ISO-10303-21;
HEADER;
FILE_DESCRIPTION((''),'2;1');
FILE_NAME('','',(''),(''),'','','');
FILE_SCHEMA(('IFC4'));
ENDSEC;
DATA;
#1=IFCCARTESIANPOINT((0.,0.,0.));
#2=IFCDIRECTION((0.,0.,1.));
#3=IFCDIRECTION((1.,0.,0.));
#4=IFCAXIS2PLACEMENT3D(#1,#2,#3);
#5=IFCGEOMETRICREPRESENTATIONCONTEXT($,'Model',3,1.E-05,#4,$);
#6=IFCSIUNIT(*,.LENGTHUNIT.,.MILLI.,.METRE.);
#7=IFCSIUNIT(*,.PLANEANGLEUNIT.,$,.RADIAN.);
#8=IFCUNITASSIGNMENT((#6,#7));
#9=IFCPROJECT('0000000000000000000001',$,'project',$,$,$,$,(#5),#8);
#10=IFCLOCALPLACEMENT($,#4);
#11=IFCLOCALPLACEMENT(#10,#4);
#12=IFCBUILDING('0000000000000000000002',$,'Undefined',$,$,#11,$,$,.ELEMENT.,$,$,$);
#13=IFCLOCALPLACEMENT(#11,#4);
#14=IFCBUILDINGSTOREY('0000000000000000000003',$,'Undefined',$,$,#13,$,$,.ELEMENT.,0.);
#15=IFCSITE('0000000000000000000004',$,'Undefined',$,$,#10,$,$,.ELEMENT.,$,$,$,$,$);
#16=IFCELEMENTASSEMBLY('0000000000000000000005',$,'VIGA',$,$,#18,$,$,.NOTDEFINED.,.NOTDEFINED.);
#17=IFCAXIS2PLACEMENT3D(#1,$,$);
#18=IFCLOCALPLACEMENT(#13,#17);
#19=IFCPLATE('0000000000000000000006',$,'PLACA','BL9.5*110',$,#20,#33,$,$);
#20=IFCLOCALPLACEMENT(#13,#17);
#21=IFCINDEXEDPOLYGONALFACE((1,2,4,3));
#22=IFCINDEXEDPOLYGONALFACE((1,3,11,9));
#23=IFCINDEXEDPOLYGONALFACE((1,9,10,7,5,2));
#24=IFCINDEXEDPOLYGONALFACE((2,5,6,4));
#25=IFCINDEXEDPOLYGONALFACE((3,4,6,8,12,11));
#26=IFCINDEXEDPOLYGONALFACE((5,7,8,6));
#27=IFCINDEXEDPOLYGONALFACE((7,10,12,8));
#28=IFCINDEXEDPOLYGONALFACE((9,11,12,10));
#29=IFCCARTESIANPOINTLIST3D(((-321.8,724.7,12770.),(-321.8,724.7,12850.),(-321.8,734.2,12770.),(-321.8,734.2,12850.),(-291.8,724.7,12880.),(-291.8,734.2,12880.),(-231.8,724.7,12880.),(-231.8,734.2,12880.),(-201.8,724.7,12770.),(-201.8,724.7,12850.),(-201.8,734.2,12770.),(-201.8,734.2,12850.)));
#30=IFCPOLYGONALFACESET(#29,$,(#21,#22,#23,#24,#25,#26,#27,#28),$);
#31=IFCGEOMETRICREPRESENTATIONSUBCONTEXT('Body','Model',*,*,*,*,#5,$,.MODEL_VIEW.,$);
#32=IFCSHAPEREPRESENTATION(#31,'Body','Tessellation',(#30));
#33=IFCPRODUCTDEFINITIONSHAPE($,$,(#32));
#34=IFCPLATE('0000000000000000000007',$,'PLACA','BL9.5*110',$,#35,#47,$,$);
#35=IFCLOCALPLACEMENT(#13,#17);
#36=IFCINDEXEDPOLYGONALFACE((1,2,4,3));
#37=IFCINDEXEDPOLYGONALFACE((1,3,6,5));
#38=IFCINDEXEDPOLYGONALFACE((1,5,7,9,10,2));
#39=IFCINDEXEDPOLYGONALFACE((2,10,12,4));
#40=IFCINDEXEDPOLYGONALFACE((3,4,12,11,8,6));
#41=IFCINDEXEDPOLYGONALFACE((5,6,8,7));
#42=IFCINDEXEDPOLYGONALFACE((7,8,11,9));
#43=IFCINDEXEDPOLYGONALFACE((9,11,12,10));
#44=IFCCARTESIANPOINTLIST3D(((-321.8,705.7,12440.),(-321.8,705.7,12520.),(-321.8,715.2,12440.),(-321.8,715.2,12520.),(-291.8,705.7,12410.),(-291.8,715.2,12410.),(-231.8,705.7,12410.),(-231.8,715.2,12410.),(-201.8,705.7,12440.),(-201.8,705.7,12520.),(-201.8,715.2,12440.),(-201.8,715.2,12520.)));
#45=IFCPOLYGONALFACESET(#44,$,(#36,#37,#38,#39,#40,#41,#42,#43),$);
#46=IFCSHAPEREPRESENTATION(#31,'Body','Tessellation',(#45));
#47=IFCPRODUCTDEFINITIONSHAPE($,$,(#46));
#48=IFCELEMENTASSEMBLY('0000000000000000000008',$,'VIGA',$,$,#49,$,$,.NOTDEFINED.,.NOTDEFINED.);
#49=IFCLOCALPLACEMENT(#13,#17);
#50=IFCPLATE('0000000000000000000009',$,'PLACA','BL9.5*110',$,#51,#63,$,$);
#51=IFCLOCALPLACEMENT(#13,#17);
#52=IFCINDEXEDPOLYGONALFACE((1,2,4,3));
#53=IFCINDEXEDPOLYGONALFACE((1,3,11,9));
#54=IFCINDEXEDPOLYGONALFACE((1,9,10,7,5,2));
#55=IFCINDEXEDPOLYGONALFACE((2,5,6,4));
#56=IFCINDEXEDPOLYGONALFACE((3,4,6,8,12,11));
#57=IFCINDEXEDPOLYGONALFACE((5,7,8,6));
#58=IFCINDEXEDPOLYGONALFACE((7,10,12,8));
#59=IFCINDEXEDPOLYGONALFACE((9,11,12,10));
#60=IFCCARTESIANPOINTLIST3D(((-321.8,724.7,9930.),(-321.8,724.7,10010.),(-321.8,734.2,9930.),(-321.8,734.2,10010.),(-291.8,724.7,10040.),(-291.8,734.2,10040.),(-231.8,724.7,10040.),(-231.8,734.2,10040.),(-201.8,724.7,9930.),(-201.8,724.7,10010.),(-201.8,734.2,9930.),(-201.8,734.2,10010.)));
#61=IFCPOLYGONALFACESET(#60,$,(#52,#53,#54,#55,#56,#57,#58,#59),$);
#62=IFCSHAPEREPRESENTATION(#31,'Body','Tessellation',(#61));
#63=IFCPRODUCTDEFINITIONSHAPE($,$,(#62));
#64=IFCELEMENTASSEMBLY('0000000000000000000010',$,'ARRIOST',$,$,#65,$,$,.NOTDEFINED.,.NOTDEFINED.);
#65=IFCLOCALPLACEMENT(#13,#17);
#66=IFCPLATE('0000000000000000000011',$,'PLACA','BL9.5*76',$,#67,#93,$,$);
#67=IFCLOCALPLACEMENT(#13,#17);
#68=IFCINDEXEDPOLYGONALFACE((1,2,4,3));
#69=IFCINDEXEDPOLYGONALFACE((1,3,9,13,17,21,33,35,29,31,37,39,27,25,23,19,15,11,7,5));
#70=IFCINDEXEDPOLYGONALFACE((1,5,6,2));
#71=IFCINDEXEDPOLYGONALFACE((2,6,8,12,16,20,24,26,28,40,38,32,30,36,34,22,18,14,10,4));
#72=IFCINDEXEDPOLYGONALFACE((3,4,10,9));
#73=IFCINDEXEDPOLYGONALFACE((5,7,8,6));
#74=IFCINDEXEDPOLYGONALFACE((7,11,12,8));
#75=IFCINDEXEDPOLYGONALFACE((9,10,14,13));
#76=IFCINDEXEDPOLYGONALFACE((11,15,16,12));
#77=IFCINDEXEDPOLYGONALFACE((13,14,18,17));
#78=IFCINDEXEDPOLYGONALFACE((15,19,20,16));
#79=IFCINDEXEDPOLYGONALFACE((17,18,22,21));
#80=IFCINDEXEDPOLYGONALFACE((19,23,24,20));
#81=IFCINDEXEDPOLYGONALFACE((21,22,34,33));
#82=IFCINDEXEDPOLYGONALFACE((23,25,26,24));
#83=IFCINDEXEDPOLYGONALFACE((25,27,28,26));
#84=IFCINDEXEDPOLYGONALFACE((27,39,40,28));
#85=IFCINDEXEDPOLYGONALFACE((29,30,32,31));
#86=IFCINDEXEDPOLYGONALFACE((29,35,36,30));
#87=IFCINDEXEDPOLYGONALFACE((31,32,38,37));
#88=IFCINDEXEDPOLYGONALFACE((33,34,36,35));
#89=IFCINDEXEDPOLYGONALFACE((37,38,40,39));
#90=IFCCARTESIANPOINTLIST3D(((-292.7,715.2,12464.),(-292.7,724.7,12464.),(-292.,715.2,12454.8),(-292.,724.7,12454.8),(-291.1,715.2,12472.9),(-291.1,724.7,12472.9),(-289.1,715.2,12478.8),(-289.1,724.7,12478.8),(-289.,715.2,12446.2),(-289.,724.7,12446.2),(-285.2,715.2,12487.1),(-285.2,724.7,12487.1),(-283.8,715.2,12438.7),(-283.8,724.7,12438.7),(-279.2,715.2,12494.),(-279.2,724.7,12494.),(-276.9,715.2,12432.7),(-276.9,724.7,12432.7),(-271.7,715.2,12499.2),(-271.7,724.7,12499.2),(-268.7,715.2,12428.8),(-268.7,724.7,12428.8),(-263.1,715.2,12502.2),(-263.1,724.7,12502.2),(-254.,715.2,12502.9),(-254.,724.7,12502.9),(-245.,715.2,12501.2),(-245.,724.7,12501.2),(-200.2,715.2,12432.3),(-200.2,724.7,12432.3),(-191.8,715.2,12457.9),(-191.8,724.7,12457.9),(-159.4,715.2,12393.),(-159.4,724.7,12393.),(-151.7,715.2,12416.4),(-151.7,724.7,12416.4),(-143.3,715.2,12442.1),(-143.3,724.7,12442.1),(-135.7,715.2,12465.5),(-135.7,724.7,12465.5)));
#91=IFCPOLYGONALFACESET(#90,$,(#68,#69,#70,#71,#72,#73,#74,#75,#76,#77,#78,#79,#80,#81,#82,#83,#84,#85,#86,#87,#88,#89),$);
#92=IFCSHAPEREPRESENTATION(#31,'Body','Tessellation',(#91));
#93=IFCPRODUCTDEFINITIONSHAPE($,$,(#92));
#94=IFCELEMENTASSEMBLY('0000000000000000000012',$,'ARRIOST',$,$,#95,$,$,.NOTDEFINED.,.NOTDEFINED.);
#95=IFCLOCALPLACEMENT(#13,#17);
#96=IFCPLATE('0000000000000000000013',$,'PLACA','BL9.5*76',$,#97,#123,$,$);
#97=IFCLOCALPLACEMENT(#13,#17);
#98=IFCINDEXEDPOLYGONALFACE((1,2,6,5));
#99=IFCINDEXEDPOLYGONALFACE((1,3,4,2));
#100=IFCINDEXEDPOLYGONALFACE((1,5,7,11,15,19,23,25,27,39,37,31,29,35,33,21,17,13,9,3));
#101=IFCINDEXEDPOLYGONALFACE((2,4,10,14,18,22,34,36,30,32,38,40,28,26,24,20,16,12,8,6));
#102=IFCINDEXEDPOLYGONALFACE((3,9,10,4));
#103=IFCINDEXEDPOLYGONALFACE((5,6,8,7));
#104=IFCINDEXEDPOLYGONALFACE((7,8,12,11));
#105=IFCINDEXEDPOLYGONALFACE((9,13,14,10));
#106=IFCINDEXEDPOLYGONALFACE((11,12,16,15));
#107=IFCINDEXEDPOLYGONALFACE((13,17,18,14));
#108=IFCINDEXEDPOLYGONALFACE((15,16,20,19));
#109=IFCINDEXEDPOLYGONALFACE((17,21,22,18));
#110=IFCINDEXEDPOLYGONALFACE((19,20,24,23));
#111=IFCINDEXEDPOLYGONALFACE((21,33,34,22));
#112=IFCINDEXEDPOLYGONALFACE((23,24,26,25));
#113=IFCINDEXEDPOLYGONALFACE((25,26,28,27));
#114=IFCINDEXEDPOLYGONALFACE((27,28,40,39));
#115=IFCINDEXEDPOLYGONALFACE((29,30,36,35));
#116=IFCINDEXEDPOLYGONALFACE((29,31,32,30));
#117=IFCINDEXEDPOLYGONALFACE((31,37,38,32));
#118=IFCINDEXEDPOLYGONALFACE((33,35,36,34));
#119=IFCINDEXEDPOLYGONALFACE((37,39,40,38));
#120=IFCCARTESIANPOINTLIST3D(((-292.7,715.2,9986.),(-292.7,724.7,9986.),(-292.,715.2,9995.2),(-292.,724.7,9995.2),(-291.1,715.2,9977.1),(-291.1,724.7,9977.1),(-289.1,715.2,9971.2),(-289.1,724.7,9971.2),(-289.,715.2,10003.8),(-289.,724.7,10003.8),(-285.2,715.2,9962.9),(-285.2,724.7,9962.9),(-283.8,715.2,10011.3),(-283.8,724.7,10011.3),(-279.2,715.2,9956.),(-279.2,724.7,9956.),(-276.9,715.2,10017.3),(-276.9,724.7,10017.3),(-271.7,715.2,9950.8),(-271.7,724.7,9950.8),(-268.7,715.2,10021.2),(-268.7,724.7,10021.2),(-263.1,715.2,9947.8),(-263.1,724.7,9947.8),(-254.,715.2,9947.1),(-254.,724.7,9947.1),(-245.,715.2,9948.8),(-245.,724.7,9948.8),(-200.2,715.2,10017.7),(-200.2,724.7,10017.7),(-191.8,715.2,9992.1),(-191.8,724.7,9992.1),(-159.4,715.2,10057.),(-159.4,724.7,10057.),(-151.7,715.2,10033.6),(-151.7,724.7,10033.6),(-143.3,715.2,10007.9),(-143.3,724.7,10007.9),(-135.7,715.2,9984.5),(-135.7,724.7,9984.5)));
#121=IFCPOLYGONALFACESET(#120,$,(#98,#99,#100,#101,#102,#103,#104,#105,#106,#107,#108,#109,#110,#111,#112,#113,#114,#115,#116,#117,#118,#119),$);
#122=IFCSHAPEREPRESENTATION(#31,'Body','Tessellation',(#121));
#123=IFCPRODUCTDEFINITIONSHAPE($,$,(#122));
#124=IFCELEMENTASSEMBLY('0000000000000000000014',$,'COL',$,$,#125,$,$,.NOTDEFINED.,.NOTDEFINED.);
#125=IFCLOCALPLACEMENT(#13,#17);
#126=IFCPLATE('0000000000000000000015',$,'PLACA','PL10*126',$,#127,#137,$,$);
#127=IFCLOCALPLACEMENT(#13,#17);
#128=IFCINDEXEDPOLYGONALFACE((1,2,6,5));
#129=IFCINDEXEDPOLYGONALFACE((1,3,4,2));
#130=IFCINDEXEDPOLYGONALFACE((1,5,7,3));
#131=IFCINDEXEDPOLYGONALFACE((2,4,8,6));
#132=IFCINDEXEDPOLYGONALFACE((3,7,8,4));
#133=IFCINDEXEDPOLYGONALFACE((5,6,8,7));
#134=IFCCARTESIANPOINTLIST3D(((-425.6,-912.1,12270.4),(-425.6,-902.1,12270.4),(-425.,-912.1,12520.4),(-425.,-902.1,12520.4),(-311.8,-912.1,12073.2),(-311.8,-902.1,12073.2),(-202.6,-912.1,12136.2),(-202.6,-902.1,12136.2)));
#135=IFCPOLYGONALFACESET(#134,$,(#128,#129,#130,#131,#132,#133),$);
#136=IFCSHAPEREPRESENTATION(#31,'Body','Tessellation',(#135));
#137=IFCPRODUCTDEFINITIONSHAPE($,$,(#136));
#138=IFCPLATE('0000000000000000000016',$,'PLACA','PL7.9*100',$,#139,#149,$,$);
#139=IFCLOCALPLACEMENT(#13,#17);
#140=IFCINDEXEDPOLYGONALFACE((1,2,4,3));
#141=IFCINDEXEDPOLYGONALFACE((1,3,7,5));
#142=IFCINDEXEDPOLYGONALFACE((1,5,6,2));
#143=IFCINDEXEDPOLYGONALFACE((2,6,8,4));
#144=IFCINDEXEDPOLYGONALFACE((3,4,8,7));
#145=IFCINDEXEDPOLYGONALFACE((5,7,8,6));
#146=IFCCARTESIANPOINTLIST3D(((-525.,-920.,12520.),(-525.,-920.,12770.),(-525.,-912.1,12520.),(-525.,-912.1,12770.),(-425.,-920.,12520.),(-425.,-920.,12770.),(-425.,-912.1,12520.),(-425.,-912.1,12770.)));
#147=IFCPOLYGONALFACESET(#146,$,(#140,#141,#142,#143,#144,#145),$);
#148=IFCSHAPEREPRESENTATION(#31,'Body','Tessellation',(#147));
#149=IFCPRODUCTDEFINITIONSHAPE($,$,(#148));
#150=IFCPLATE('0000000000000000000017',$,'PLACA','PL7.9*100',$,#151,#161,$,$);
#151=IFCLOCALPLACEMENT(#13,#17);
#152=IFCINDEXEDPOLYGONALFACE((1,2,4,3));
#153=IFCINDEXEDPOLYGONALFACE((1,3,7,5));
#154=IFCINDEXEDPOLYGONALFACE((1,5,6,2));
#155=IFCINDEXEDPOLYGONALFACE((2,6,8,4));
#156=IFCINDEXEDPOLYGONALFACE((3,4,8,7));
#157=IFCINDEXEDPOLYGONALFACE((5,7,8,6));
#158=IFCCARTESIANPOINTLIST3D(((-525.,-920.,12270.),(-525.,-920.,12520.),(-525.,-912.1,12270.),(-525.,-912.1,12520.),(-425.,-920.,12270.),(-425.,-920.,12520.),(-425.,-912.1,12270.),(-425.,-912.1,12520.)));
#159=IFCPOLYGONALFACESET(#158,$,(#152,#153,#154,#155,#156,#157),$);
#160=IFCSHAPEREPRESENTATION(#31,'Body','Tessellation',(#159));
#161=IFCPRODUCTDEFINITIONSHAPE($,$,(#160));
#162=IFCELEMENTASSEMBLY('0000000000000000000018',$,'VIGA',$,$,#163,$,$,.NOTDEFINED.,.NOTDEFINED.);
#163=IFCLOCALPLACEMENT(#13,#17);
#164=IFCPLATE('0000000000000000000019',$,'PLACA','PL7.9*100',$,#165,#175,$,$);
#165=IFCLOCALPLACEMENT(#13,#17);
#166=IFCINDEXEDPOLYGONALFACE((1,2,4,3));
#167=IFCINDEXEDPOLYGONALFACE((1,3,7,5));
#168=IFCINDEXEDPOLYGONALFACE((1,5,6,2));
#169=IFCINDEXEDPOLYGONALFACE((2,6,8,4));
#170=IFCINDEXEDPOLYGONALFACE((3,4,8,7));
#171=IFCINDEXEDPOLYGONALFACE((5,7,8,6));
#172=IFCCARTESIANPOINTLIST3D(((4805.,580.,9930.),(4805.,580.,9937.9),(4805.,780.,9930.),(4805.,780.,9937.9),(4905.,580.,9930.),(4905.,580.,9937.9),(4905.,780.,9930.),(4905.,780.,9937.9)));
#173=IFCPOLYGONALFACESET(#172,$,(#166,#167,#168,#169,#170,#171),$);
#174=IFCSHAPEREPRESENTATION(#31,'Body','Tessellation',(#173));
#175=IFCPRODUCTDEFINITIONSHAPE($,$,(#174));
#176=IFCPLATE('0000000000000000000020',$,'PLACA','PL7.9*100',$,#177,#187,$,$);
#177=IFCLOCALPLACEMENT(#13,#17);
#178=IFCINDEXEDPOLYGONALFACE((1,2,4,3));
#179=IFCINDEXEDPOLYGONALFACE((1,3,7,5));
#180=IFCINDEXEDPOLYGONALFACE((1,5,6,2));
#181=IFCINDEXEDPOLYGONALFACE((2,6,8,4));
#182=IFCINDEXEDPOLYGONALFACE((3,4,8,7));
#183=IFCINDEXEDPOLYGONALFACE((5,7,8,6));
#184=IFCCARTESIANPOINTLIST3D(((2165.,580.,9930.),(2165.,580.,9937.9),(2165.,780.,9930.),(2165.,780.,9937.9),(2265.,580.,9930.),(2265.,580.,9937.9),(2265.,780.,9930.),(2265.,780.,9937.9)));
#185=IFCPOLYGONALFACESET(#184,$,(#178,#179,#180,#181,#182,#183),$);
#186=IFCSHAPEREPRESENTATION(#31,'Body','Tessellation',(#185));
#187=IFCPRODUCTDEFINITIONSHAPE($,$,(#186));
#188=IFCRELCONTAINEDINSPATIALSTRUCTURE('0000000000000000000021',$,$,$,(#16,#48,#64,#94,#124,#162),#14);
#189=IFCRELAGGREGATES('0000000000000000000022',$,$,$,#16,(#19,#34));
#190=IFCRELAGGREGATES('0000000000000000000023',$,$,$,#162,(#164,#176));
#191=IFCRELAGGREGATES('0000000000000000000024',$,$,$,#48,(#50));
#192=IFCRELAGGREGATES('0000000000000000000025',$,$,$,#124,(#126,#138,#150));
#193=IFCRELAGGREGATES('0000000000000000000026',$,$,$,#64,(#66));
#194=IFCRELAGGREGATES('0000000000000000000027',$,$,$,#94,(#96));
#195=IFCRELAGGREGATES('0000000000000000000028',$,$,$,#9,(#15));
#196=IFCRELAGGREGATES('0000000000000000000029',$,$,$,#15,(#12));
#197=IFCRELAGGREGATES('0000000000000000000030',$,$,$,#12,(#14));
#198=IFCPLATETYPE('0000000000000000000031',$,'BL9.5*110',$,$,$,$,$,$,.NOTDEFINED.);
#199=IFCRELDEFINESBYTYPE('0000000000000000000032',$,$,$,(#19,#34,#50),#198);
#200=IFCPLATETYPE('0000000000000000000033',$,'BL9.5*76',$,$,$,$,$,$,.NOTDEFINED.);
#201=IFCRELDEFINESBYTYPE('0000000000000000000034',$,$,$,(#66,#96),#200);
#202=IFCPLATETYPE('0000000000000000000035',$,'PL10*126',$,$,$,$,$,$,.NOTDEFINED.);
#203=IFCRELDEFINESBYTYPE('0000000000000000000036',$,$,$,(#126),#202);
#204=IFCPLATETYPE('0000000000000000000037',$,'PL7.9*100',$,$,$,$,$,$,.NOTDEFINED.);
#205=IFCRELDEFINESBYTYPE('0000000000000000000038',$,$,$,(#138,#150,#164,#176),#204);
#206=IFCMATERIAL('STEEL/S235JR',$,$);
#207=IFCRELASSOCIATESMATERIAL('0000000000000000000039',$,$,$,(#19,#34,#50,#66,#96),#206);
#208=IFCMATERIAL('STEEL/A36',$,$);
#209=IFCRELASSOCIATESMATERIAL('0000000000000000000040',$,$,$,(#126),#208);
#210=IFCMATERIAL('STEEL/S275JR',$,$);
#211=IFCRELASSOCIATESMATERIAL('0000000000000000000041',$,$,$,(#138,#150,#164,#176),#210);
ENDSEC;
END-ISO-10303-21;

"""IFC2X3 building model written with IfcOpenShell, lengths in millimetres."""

from ifc_helpers import new_model, si_unit, frame, frame_2d, origin_with_axes, origin_2d_with_axis, place, context, subcontext, project, spatial, polyline, circle_curve, parameter, trimmed, segment, composite_curve, rectangle, outline, extrude, boolean, material, type_object, element, aggregate, save


model = new_model("IFC2X3")

# Units and contexts
model_context = context("Model", 3, precision=1e-05, world=origin_with_axes())
body_context = subcontext(model_context, "Body", "Model", "MODEL_VIEW")
ifc_project = project(units=[si_unit("LENGTHUNIT", "METRE", prefix="MILLI"), si_unit("PLANEANGLEUNIT", "RADIAN")], contexts=[model_context])

# Site, building, storey
site_placement = place(None, origin_with_axes())
site = spatial("IfcSite", under=ifc_project, at=site_placement, Name="Undefined", CompositionType="ELEMENT")
building_placement = place(site_placement, origin_with_axes())
building = spatial("IfcBuilding", under=site, at=building_placement, Name="Undefined", CompositionType="ELEMENT")
storey_placement = place(building_placement, origin_with_axes())
storey = spatial("IfcBuildingStorey", under=building, at=storey_placement, Name="Undefined", CompositionType="ELEMENT", Elevation=0.0)

# Element assembly, plates
assembly_1_placement = place(storey_placement, origin_with_axes())
assembly_1 = element("IfcElementAssembly", 1, at=assembly_1_placement, inside=storey, Name="VIGA", AssemblyPlace="NOTDEFINED", PredefinedType="NOTDEFINED")
ifc_material_1 = material(Name="STEEL/S235JR")
plate_type_1 = type_object("IfcPlateType", Name="BL9.5*110", PredefinedType="NOTDEFINED")
plate_1_placement = place(assembly_1_placement, frame((-201.8, 729.5, 12770.0), z_axis=(0.0, -1.0, 0.0), x_axis=(0.0, 0.0, 1.0)))
plate_1 = element("IfcPlate", 2, at=plate_1_placement, type_object=plate_type_1, material=ifc_material_1, Name="PLACA", Description="BL9.5*110", context=body_context, shape_type="SweptSolid", body=[
    extrude(outline(polyline([(0.0, 0.0), (80.0, 0.0), (110.0, 30.0), (110.0, 90.0), (80.0, 120.0), (0.0, 120.0), (0.0, 0.0)])), frame((0.0, 0.0, -4.7), z_axis=(0.0, 0.0, 1.0), x_axis=(1.0, 0.0, 0.0)), (0.0, 0.0, 1.0), 9.5),
])
plate_2_placement = place(assembly_1_placement, frame((-201.8, 710.5, 12520.0), z_axis=(0.0, 1.0, 0.0), x_axis=(0.0, 0.0, -1.0)))
plate_2 = element("IfcPlate", 3, at=plate_2_placement, type_object=plate_type_1, material=ifc_material_1, Name="PLACA", Description="BL9.5*110", context=body_context, shape_type="SweptSolid", body=[
    extrude(outline(polyline([(0.0, 0.0), (80.0, 0.0), (110.0, 30.0), (110.0, 90.0), (80.0, 120.0), (0.0, 120.0), (0.0, 0.0)])), frame((0.0, 0.0, -4.7), z_axis=(0.0, 0.0, 1.0), x_axis=(1.0, 0.0, 0.0)), (0.0, 0.0, 1.0), 9.5),
])

# Element assemblies, plates
assembly_2_placement = place(storey_placement, origin_with_axes())
assembly_2 = element("IfcElementAssembly", 4, at=assembly_2_placement, inside=storey, Name="VIGA", AssemblyPlace="NOTDEFINED", PredefinedType="NOTDEFINED")
plate_3_placement = place(assembly_2_placement, frame((-201.8, 729.5, 9930.0), z_axis=(0.0, -1.0, 0.0), x_axis=(0.0, 0.0, 1.0)))
plate_3 = element("IfcPlate", 5, at=plate_3_placement, type_object=plate_type_1, material=ifc_material_1, Name="PLACA", Description="BL9.5*110", context=body_context, shape_type="SweptSolid", body=[
    extrude(outline(polyline([(0.0, 0.0), (80.0, 0.0), (110.0, 30.0), (110.0, 90.0), (80.0, 120.0), (0.0, 120.0), (0.0, 0.0)])), frame((0.0, 0.0, -4.7), z_axis=(0.0, 0.0, 1.0), x_axis=(1.0, 0.0, 0.0)), (0.0, 0.0, 1.0), 9.5),
])
assembly_3_placement = place(storey_placement, origin_with_axes())
assembly_3 = element("IfcElementAssembly", 6, at=assembly_3_placement, inside=storey, Name="ARRIOST", AssemblyPlace="NOTDEFINED", PredefinedType="NOTDEFINED")
plate_type_2 = type_object("IfcPlateType", Name="BL9.5*76", PredefinedType="NOTDEFINED")
plate_4_placement = place(assembly_3_placement, frame((-301.9, 720.0, 12439.7), z_axis=(0.0, 1.0, 0.0), x_axis=(0.310857, 0.0, 0.950457)))
plate_4 = element("IfcPlate", 7, at=plate_4_placement, type_object=plate_type_2, material=ifc_material_1, Name="PLACA", Description="BL9.5*76", context=body_context, shape_type="CSG", body=[
    boolean("DIFFERENCE", extrude(outline(composite_curve([segment(trimmed(circle_curve(frame_2d((35.0, 35.0), x_axis=(-1.0, 0.0)), 35.0), [parameter(0.0)], [parameter(1.570796)], True, "PARAMETER"), True, "CONTINUOUS"), segment(polyline([(35.0, 0.0), (41.2, 0.0)]), True, "CONTINUOUS"), segment(trimmed(circle_curve(frame_2d((41.2, 35.0), x_axis=(0.0, -1.0)), 35.0), [parameter(0.0)], [parameter(1.570796)], True, "PARAMETER"), True, "CONTINUOUS"), segment(polyline([(76.2, 35.0), (76.2, 150.0), (0.0, 150.0), (0.0, 35.0)]), True, "CONTINUOUS")], self_intersect=True)), frame((0.0, 0.0, -4.7), z_axis=(0.0, 0.0, 1.0), x_axis=(1.0, 0.0, 0.0)), (0.0, 0.0, 1.0), 9.5), extrude(rectangle(XDim=27.0, YDim=27.0, at=origin_2d_with_axis()), frame((38.1, 250.0, 0.0), z_axis=(0.0, -1.0, 0.0), x_axis=(-1.0, 0.0, 0.0)), (0.0, 0.0, 1.0), 151.0)),
])
assembly_4_placement = place(storey_placement, origin_with_axes())
assembly_4 = element("IfcElementAssembly", 8, at=assembly_4_placement, inside=storey, Name="ARRIOST", AssemblyPlace="NOTDEFINED", PredefinedType="NOTDEFINED")
plate_5_placement = place(assembly_4_placement, frame((-301.9, 720.0, 10010.3), z_axis=(0.0, -1.0, 0.0), x_axis=(0.310822, 0.0, -0.950468)))
plate_5 = element("IfcPlate", 9, at=plate_5_placement, type_object=plate_type_2, material=ifc_material_1, Name="PLACA", Description="BL9.5*76", context=body_context, shape_type="CSG", body=[
    boolean("DIFFERENCE", extrude(outline(composite_curve([segment(trimmed(circle_curve(frame_2d((35.0, 35.0), x_axis=(-1.0, 0.0)), 35.0), [parameter(0.0)], [parameter(1.570796)], True, "PARAMETER"), True, "CONTINUOUS"), segment(polyline([(35.0, 0.0), (41.2, 0.0)]), True, "CONTINUOUS"), segment(trimmed(circle_curve(frame_2d((41.2, 35.0), x_axis=(0.0, -1.0)), 35.0), [parameter(0.0)], [parameter(1.570796)], True, "PARAMETER"), True, "CONTINUOUS"), segment(polyline([(76.2, 35.0), (76.2, 150.0), (0.0, 150.0), (0.0, 35.0)]), True, "CONTINUOUS")], self_intersect=True)), frame((0.0, 0.0, -4.7), z_axis=(0.0, 0.0, 1.0), x_axis=(1.0, 0.0, 0.0)), (0.0, 0.0, 1.0), 9.5), extrude(rectangle(XDim=27.0, YDim=27.0, at=origin_2d_with_axis()), frame((38.1, 250.0, 0.0), z_axis=(0.0, -1.0, 0.0), x_axis=(1.0, 0.0, 0.0)), (0.0, 0.0, 1.0), 151.0)),
])

# Element assemblies, plates
assembly_5_placement = place(storey_placement, origin_with_axes())
assembly_5 = element("IfcElementAssembly", 10, at=assembly_5_placement, inside=storey, Name="COL", AssemblyPlace="NOTDEFINED", PredefinedType="NOTDEFINED")
ifc_material_2 = material(Name="STEEL/A36")
plate_type_3 = type_object("IfcPlateType", Name="PL10*126", PredefinedType="NOTDEFINED")
plate_6_placement = place(assembly_5_placement, frame((-425.0, -907.1, 12520.4), z_axis=(0.0, 1.0, 0.0), x_axis=(0.500975, 0.0, -0.865462)))
plate_6 = element("IfcPlate", 11, at=plate_6_placement, type_object=plate_type_3, material=ifc_material_2, Name="PLACA", Description="PL10*126", context=body_context, shape_type="SweptSolid", body=[
    extrude(outline(polyline([(0.0, 0.0), (443.9, 0.0), (443.7, 126.0), (216.1, 125.7), (0.0, 0.0)])), frame((0.0, 0.0, -5.0), z_axis=(0.0, 0.0, 1.0), x_axis=(1.0, 0.0, 0.0)), (0.0, 0.0, 1.0), 10.0),
])
ifc_material_3 = material(Name="STEEL/S275JR")
plate_type_4 = type_object("IfcPlateType", Name="PL7.9*100", PredefinedType="NOTDEFINED")
plate_7_placement = place(assembly_5_placement, frame((-525.0, -916.0, 12520.0), z_axis=(0.0, 1.0, 0.0), x_axis=(0.0, 0.0, 1.0)))
plate_7 = element("IfcPlate", 12, at=plate_7_placement, type_object=plate_type_4, material=ifc_material_3, Name="PLACA", Description="PL7.9*100", context=body_context, shape_type="SweptSolid", body=[
    extrude(outline(polyline([(0.0, 0.0), (250.0, 0.0), (250.0, 100.0), (0.0, 100.0), (0.0, 0.0)])), frame((0.0, 0.0, -4.0), z_axis=(0.0, 0.0, 1.0), x_axis=(1.0, 0.0, 0.0)), (0.0, 0.0, 1.0), 7.9),
])
plate_8_placement = place(assembly_5_placement, frame((-525.0, -916.0, 12270.0), z_axis=(0.0, 1.0, 0.0), x_axis=(0.0, 0.0, 1.0)))
plate_8 = element("IfcPlate", 13, at=plate_8_placement, type_object=plate_type_4, material=ifc_material_3, Name="PLACA", Description="PL7.9*100", context=body_context, shape_type="SweptSolid", body=[
    extrude(outline(polyline([(0.0, 0.0), (250.0, 0.0), (250.0, 100.0), (0.0, 100.0), (0.0, 0.0)])), frame((0.0, 0.0, -4.0), z_axis=(0.0, 0.0, 1.0), x_axis=(1.0, 0.0, 0.0)), (0.0, 0.0, 1.0), 7.9),
])
assembly_6_placement = place(storey_placement, origin_with_axes())
assembly_6 = element("IfcElementAssembly", 14, at=assembly_6_placement, inside=storey, Name="VIGA", AssemblyPlace="NOTDEFINED", PredefinedType="NOTDEFINED")
plate_9_placement = place(assembly_6_placement, frame((4905.0, 580.0, 9934.0), z_axis=(0.0, 0.0, -1.0), x_axis=(-1.0, 0.0, 0.0)))
plate_9 = element("IfcPlate", 15, at=plate_9_placement, type_object=plate_type_4, material=ifc_material_3, Name="PLACA", Description="PL7.9*100", context=body_context, shape_type="SweptSolid", body=[
    extrude(outline(polyline([(0.0, 0.0), (100.0, 0.0), (100.0, 200.0), (0.0, 200.0), (0.0, 0.0)])), frame((0.0, 0.0, -4.0), z_axis=(0.0, 0.0, 1.0), x_axis=(1.0, 0.0, 0.0)), (0.0, 0.0, 1.0), 7.9),
])
plate_10_placement = place(assembly_6_placement, frame((2265.0, 580.0, 9934.0), z_axis=(0.0, 0.0, -1.0), x_axis=(-1.0, 0.0, 0.0)))
plate_10 = element("IfcPlate", 16, at=plate_10_placement, type_object=plate_type_4, material=ifc_material_3, Name="PLACA", Description="PL7.9*100", context=body_context, shape_type="SweptSolid", body=[
    extrude(outline(polyline([(0.0, 0.0), (100.0, 0.0), (100.0, 200.0), (0.0, 200.0), (0.0, 0.0)])), frame((0.0, 0.0, -4.0), z_axis=(0.0, 0.0, 1.0), x_axis=(1.0, 0.0, 0.0)), (0.0, 0.0, 1.0), 7.9),
])

aggregate(assembly_1, [plate_1, plate_2])
aggregate(assembly_6, [plate_9, plate_10])
aggregate(assembly_2, [plate_3])

aggregate(assembly_5, [plate_6, plate_7, plate_8])

aggregate(assembly_3, [plate_4])
aggregate(assembly_4, [plate_5])

save(model, "model.ifc")
